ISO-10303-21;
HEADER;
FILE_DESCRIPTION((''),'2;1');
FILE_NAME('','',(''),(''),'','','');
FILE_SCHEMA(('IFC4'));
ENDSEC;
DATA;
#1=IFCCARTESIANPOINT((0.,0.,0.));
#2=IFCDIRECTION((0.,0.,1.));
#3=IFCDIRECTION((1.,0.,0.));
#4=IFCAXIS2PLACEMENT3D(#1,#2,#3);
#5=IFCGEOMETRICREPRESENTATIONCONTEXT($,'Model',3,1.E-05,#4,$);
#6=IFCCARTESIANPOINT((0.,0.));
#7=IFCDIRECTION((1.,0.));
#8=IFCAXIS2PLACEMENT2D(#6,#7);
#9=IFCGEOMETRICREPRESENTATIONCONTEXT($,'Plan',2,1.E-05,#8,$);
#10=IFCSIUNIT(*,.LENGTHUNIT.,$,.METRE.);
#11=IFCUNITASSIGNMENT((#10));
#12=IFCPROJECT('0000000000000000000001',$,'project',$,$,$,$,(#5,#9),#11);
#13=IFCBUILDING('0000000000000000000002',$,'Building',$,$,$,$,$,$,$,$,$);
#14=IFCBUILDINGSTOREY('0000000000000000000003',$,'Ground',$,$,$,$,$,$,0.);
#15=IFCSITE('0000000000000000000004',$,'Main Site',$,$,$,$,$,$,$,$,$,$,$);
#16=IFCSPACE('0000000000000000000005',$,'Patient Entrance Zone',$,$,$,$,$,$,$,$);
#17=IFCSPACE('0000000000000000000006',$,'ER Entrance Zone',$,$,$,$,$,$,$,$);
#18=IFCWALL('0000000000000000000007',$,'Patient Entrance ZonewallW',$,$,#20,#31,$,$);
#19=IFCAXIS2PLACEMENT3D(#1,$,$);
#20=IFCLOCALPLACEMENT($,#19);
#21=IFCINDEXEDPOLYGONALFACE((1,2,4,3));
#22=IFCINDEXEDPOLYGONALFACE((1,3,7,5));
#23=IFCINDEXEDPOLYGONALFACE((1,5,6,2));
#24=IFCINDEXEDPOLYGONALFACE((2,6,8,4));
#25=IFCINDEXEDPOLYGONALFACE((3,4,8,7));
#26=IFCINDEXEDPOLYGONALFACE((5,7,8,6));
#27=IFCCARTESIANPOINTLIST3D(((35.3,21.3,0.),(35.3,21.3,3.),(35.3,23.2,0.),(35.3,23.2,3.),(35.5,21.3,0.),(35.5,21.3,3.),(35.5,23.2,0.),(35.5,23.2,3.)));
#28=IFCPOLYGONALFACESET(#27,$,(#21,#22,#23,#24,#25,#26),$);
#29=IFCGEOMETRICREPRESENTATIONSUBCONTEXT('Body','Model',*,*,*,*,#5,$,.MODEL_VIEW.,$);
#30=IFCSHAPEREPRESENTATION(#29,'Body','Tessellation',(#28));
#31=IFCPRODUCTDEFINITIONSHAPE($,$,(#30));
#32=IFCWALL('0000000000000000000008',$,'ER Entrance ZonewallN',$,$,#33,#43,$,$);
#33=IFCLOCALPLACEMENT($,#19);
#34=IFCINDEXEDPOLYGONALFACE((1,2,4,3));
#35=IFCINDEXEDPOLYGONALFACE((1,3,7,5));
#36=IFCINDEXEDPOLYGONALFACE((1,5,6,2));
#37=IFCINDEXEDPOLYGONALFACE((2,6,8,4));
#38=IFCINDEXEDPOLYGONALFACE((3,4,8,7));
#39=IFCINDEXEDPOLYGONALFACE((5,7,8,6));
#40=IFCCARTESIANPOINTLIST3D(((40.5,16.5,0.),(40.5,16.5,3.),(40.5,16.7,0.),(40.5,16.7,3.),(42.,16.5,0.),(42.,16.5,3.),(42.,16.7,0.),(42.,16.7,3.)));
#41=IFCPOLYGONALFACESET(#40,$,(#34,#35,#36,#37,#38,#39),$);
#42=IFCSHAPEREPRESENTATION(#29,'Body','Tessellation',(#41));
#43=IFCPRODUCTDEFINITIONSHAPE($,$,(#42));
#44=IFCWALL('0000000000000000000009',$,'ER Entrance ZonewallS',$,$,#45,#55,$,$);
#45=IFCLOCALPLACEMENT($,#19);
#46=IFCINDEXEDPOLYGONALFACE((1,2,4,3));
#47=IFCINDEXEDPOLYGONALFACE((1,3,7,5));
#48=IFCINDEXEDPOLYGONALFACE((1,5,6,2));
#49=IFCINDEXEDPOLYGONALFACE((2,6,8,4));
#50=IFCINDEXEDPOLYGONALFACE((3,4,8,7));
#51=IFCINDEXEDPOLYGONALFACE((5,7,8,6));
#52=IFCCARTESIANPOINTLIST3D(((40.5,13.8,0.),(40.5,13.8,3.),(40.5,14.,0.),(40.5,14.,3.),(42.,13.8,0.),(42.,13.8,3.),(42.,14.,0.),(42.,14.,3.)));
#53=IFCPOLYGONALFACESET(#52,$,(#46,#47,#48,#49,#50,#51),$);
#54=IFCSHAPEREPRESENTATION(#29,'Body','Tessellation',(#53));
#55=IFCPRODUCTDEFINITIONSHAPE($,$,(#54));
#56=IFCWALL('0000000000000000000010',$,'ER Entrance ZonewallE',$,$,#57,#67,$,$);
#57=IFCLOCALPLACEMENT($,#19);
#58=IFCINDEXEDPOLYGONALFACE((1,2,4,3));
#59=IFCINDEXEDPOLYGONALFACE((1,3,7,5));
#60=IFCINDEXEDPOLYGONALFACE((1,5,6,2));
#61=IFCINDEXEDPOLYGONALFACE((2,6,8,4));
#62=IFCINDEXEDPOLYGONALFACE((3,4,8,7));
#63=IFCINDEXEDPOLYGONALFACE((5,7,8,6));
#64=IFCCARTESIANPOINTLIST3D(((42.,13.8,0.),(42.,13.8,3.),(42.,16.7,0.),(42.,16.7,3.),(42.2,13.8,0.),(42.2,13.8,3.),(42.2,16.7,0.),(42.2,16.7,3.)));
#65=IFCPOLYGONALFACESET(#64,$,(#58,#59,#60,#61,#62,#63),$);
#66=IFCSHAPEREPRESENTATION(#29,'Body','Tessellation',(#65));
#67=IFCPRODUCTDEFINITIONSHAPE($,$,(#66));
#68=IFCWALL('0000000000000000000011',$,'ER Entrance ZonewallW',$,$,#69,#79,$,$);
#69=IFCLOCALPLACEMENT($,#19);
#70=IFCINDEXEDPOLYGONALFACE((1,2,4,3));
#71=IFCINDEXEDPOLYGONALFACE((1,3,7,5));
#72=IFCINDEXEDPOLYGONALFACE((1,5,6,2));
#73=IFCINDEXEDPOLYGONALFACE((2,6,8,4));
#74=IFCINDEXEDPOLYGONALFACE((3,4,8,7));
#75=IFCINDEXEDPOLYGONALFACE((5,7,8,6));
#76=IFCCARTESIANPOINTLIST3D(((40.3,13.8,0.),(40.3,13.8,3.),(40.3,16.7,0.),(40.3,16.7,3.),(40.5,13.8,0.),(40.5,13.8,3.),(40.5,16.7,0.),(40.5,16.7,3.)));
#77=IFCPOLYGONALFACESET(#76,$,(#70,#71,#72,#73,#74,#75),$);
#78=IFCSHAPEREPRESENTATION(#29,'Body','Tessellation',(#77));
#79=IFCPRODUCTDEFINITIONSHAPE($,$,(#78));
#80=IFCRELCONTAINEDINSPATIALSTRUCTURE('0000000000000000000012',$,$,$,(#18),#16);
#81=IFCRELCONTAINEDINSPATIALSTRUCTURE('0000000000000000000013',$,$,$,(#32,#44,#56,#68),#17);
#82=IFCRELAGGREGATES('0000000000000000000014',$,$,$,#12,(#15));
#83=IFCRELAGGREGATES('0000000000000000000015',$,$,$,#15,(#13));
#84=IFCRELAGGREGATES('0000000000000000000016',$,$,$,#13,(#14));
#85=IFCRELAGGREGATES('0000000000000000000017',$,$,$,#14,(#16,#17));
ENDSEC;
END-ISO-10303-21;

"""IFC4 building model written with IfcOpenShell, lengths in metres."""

from ifc_helpers import new_model, si_unit, frame, origin_with_axes, origin_2d_with_axis, place, context, subcontext, project, spatial, indexed_curve, outline, extrude, element, save


model = new_model("IFC4")

# Units and contexts
model_context = context("Model", 3, precision=1e-05, world=origin_with_axes())
plan_context = context("Plan", 2, precision=1e-05, world=origin_2d_with_axis())
body_context = subcontext(model_context, "Body", "Model", "MODEL_VIEW")
ifc_project = project(units=[si_unit("LENGTHUNIT", "METRE")], contexts=[model_context, plan_context])

# Site, building, storey
site = spatial("IfcSite", under=ifc_project, Name="Main Site")
building = spatial("IfcBuilding", under=site, Name="Building")
storey = spatial("IfcBuildingStorey", under=building, Name="Ground", Elevation=0.0)

# Shared definitions
space_1 = spatial("IfcSpace", under=storey, Name="Patient Entrance Zone")

# Shared definitions
space_2 = spatial("IfcSpace", under=storey, Name="ER Entrance Zone")

# Walls
for number, where, z_axis, x_axis, name in (
    (1, (35.5, 21.3, 0.0), (0.0, 0.0, 1.0), (0.0, 1.0, 0.0), "Patient Entrance ZonewallW"),
):
    element("IfcWall", number, at=place(None, frame(where, z_axis=z_axis, x_axis=x_axis)), inside=space_1, Name=name, context=body_context, shape_type="SweptSolid", body=[
        extrude(outline(indexed_curve([(0.0, 0.0), (0.0, 0.2), (1.9, 0.2), (1.9, 0.0), (0.0, 0.0)], self_intersect=False)), origin_with_axes(), (0.0, 0.0, 1.0), 3.0),
    ])
for number, where, z_axis, x_axis, name in (
    (2, (40.5, 16.5, 0.0), (0.0, 0.0, 1.0), (1.0, 0.0, 0.0), "ER Entrance ZonewallN"),
    (3, (40.5, 13.8, 0.0), (0.0, 0.0, 1.0), (1.0, 0.0, 0.0), "ER Entrance ZonewallS"),
):
    element("IfcWall", number, at=place(None, frame(where, z_axis=z_axis, x_axis=x_axis)), inside=space_2, Name=name, context=body_context, shape_type="SweptSolid", body=[
        extrude(outline(indexed_curve([(0.0, 0.0), (0.0, 0.2), (1.5, 0.2), (1.5, 0.0), (0.0, 0.0)], self_intersect=False)), origin_with_axes(), (0.0, 0.0, 1.0), 3.0),
    ])
for number, where, z_axis, x_axis, name in (
    (4, (42.2, 13.8, 0.0), (0.0, 0.0, 1.0), (0.0, 1.0, 0.0), "ER Entrance ZonewallE"),
    (5, (40.5, 13.8, 0.0), (0.0, 0.0, 1.0), (0.0, 1.0, 0.0), "ER Entrance ZonewallW"),
):
    element("IfcWall", number, at=place(None, frame(where, z_axis=z_axis, x_axis=x_axis)), inside=space_2, Name=name, context=body_context, shape_type="SweptSolid", body=[
        extrude(outline(indexed_curve([(0.0, 0.0), (0.0, 0.2), (2.9, 0.2), (2.9, 0.0), (0.0, 0.0)], self_intersect=False)), origin_with_axes(), (0.0, 0.0, 1.0), 3.0),
    ])

save(model, "model.ifc")
